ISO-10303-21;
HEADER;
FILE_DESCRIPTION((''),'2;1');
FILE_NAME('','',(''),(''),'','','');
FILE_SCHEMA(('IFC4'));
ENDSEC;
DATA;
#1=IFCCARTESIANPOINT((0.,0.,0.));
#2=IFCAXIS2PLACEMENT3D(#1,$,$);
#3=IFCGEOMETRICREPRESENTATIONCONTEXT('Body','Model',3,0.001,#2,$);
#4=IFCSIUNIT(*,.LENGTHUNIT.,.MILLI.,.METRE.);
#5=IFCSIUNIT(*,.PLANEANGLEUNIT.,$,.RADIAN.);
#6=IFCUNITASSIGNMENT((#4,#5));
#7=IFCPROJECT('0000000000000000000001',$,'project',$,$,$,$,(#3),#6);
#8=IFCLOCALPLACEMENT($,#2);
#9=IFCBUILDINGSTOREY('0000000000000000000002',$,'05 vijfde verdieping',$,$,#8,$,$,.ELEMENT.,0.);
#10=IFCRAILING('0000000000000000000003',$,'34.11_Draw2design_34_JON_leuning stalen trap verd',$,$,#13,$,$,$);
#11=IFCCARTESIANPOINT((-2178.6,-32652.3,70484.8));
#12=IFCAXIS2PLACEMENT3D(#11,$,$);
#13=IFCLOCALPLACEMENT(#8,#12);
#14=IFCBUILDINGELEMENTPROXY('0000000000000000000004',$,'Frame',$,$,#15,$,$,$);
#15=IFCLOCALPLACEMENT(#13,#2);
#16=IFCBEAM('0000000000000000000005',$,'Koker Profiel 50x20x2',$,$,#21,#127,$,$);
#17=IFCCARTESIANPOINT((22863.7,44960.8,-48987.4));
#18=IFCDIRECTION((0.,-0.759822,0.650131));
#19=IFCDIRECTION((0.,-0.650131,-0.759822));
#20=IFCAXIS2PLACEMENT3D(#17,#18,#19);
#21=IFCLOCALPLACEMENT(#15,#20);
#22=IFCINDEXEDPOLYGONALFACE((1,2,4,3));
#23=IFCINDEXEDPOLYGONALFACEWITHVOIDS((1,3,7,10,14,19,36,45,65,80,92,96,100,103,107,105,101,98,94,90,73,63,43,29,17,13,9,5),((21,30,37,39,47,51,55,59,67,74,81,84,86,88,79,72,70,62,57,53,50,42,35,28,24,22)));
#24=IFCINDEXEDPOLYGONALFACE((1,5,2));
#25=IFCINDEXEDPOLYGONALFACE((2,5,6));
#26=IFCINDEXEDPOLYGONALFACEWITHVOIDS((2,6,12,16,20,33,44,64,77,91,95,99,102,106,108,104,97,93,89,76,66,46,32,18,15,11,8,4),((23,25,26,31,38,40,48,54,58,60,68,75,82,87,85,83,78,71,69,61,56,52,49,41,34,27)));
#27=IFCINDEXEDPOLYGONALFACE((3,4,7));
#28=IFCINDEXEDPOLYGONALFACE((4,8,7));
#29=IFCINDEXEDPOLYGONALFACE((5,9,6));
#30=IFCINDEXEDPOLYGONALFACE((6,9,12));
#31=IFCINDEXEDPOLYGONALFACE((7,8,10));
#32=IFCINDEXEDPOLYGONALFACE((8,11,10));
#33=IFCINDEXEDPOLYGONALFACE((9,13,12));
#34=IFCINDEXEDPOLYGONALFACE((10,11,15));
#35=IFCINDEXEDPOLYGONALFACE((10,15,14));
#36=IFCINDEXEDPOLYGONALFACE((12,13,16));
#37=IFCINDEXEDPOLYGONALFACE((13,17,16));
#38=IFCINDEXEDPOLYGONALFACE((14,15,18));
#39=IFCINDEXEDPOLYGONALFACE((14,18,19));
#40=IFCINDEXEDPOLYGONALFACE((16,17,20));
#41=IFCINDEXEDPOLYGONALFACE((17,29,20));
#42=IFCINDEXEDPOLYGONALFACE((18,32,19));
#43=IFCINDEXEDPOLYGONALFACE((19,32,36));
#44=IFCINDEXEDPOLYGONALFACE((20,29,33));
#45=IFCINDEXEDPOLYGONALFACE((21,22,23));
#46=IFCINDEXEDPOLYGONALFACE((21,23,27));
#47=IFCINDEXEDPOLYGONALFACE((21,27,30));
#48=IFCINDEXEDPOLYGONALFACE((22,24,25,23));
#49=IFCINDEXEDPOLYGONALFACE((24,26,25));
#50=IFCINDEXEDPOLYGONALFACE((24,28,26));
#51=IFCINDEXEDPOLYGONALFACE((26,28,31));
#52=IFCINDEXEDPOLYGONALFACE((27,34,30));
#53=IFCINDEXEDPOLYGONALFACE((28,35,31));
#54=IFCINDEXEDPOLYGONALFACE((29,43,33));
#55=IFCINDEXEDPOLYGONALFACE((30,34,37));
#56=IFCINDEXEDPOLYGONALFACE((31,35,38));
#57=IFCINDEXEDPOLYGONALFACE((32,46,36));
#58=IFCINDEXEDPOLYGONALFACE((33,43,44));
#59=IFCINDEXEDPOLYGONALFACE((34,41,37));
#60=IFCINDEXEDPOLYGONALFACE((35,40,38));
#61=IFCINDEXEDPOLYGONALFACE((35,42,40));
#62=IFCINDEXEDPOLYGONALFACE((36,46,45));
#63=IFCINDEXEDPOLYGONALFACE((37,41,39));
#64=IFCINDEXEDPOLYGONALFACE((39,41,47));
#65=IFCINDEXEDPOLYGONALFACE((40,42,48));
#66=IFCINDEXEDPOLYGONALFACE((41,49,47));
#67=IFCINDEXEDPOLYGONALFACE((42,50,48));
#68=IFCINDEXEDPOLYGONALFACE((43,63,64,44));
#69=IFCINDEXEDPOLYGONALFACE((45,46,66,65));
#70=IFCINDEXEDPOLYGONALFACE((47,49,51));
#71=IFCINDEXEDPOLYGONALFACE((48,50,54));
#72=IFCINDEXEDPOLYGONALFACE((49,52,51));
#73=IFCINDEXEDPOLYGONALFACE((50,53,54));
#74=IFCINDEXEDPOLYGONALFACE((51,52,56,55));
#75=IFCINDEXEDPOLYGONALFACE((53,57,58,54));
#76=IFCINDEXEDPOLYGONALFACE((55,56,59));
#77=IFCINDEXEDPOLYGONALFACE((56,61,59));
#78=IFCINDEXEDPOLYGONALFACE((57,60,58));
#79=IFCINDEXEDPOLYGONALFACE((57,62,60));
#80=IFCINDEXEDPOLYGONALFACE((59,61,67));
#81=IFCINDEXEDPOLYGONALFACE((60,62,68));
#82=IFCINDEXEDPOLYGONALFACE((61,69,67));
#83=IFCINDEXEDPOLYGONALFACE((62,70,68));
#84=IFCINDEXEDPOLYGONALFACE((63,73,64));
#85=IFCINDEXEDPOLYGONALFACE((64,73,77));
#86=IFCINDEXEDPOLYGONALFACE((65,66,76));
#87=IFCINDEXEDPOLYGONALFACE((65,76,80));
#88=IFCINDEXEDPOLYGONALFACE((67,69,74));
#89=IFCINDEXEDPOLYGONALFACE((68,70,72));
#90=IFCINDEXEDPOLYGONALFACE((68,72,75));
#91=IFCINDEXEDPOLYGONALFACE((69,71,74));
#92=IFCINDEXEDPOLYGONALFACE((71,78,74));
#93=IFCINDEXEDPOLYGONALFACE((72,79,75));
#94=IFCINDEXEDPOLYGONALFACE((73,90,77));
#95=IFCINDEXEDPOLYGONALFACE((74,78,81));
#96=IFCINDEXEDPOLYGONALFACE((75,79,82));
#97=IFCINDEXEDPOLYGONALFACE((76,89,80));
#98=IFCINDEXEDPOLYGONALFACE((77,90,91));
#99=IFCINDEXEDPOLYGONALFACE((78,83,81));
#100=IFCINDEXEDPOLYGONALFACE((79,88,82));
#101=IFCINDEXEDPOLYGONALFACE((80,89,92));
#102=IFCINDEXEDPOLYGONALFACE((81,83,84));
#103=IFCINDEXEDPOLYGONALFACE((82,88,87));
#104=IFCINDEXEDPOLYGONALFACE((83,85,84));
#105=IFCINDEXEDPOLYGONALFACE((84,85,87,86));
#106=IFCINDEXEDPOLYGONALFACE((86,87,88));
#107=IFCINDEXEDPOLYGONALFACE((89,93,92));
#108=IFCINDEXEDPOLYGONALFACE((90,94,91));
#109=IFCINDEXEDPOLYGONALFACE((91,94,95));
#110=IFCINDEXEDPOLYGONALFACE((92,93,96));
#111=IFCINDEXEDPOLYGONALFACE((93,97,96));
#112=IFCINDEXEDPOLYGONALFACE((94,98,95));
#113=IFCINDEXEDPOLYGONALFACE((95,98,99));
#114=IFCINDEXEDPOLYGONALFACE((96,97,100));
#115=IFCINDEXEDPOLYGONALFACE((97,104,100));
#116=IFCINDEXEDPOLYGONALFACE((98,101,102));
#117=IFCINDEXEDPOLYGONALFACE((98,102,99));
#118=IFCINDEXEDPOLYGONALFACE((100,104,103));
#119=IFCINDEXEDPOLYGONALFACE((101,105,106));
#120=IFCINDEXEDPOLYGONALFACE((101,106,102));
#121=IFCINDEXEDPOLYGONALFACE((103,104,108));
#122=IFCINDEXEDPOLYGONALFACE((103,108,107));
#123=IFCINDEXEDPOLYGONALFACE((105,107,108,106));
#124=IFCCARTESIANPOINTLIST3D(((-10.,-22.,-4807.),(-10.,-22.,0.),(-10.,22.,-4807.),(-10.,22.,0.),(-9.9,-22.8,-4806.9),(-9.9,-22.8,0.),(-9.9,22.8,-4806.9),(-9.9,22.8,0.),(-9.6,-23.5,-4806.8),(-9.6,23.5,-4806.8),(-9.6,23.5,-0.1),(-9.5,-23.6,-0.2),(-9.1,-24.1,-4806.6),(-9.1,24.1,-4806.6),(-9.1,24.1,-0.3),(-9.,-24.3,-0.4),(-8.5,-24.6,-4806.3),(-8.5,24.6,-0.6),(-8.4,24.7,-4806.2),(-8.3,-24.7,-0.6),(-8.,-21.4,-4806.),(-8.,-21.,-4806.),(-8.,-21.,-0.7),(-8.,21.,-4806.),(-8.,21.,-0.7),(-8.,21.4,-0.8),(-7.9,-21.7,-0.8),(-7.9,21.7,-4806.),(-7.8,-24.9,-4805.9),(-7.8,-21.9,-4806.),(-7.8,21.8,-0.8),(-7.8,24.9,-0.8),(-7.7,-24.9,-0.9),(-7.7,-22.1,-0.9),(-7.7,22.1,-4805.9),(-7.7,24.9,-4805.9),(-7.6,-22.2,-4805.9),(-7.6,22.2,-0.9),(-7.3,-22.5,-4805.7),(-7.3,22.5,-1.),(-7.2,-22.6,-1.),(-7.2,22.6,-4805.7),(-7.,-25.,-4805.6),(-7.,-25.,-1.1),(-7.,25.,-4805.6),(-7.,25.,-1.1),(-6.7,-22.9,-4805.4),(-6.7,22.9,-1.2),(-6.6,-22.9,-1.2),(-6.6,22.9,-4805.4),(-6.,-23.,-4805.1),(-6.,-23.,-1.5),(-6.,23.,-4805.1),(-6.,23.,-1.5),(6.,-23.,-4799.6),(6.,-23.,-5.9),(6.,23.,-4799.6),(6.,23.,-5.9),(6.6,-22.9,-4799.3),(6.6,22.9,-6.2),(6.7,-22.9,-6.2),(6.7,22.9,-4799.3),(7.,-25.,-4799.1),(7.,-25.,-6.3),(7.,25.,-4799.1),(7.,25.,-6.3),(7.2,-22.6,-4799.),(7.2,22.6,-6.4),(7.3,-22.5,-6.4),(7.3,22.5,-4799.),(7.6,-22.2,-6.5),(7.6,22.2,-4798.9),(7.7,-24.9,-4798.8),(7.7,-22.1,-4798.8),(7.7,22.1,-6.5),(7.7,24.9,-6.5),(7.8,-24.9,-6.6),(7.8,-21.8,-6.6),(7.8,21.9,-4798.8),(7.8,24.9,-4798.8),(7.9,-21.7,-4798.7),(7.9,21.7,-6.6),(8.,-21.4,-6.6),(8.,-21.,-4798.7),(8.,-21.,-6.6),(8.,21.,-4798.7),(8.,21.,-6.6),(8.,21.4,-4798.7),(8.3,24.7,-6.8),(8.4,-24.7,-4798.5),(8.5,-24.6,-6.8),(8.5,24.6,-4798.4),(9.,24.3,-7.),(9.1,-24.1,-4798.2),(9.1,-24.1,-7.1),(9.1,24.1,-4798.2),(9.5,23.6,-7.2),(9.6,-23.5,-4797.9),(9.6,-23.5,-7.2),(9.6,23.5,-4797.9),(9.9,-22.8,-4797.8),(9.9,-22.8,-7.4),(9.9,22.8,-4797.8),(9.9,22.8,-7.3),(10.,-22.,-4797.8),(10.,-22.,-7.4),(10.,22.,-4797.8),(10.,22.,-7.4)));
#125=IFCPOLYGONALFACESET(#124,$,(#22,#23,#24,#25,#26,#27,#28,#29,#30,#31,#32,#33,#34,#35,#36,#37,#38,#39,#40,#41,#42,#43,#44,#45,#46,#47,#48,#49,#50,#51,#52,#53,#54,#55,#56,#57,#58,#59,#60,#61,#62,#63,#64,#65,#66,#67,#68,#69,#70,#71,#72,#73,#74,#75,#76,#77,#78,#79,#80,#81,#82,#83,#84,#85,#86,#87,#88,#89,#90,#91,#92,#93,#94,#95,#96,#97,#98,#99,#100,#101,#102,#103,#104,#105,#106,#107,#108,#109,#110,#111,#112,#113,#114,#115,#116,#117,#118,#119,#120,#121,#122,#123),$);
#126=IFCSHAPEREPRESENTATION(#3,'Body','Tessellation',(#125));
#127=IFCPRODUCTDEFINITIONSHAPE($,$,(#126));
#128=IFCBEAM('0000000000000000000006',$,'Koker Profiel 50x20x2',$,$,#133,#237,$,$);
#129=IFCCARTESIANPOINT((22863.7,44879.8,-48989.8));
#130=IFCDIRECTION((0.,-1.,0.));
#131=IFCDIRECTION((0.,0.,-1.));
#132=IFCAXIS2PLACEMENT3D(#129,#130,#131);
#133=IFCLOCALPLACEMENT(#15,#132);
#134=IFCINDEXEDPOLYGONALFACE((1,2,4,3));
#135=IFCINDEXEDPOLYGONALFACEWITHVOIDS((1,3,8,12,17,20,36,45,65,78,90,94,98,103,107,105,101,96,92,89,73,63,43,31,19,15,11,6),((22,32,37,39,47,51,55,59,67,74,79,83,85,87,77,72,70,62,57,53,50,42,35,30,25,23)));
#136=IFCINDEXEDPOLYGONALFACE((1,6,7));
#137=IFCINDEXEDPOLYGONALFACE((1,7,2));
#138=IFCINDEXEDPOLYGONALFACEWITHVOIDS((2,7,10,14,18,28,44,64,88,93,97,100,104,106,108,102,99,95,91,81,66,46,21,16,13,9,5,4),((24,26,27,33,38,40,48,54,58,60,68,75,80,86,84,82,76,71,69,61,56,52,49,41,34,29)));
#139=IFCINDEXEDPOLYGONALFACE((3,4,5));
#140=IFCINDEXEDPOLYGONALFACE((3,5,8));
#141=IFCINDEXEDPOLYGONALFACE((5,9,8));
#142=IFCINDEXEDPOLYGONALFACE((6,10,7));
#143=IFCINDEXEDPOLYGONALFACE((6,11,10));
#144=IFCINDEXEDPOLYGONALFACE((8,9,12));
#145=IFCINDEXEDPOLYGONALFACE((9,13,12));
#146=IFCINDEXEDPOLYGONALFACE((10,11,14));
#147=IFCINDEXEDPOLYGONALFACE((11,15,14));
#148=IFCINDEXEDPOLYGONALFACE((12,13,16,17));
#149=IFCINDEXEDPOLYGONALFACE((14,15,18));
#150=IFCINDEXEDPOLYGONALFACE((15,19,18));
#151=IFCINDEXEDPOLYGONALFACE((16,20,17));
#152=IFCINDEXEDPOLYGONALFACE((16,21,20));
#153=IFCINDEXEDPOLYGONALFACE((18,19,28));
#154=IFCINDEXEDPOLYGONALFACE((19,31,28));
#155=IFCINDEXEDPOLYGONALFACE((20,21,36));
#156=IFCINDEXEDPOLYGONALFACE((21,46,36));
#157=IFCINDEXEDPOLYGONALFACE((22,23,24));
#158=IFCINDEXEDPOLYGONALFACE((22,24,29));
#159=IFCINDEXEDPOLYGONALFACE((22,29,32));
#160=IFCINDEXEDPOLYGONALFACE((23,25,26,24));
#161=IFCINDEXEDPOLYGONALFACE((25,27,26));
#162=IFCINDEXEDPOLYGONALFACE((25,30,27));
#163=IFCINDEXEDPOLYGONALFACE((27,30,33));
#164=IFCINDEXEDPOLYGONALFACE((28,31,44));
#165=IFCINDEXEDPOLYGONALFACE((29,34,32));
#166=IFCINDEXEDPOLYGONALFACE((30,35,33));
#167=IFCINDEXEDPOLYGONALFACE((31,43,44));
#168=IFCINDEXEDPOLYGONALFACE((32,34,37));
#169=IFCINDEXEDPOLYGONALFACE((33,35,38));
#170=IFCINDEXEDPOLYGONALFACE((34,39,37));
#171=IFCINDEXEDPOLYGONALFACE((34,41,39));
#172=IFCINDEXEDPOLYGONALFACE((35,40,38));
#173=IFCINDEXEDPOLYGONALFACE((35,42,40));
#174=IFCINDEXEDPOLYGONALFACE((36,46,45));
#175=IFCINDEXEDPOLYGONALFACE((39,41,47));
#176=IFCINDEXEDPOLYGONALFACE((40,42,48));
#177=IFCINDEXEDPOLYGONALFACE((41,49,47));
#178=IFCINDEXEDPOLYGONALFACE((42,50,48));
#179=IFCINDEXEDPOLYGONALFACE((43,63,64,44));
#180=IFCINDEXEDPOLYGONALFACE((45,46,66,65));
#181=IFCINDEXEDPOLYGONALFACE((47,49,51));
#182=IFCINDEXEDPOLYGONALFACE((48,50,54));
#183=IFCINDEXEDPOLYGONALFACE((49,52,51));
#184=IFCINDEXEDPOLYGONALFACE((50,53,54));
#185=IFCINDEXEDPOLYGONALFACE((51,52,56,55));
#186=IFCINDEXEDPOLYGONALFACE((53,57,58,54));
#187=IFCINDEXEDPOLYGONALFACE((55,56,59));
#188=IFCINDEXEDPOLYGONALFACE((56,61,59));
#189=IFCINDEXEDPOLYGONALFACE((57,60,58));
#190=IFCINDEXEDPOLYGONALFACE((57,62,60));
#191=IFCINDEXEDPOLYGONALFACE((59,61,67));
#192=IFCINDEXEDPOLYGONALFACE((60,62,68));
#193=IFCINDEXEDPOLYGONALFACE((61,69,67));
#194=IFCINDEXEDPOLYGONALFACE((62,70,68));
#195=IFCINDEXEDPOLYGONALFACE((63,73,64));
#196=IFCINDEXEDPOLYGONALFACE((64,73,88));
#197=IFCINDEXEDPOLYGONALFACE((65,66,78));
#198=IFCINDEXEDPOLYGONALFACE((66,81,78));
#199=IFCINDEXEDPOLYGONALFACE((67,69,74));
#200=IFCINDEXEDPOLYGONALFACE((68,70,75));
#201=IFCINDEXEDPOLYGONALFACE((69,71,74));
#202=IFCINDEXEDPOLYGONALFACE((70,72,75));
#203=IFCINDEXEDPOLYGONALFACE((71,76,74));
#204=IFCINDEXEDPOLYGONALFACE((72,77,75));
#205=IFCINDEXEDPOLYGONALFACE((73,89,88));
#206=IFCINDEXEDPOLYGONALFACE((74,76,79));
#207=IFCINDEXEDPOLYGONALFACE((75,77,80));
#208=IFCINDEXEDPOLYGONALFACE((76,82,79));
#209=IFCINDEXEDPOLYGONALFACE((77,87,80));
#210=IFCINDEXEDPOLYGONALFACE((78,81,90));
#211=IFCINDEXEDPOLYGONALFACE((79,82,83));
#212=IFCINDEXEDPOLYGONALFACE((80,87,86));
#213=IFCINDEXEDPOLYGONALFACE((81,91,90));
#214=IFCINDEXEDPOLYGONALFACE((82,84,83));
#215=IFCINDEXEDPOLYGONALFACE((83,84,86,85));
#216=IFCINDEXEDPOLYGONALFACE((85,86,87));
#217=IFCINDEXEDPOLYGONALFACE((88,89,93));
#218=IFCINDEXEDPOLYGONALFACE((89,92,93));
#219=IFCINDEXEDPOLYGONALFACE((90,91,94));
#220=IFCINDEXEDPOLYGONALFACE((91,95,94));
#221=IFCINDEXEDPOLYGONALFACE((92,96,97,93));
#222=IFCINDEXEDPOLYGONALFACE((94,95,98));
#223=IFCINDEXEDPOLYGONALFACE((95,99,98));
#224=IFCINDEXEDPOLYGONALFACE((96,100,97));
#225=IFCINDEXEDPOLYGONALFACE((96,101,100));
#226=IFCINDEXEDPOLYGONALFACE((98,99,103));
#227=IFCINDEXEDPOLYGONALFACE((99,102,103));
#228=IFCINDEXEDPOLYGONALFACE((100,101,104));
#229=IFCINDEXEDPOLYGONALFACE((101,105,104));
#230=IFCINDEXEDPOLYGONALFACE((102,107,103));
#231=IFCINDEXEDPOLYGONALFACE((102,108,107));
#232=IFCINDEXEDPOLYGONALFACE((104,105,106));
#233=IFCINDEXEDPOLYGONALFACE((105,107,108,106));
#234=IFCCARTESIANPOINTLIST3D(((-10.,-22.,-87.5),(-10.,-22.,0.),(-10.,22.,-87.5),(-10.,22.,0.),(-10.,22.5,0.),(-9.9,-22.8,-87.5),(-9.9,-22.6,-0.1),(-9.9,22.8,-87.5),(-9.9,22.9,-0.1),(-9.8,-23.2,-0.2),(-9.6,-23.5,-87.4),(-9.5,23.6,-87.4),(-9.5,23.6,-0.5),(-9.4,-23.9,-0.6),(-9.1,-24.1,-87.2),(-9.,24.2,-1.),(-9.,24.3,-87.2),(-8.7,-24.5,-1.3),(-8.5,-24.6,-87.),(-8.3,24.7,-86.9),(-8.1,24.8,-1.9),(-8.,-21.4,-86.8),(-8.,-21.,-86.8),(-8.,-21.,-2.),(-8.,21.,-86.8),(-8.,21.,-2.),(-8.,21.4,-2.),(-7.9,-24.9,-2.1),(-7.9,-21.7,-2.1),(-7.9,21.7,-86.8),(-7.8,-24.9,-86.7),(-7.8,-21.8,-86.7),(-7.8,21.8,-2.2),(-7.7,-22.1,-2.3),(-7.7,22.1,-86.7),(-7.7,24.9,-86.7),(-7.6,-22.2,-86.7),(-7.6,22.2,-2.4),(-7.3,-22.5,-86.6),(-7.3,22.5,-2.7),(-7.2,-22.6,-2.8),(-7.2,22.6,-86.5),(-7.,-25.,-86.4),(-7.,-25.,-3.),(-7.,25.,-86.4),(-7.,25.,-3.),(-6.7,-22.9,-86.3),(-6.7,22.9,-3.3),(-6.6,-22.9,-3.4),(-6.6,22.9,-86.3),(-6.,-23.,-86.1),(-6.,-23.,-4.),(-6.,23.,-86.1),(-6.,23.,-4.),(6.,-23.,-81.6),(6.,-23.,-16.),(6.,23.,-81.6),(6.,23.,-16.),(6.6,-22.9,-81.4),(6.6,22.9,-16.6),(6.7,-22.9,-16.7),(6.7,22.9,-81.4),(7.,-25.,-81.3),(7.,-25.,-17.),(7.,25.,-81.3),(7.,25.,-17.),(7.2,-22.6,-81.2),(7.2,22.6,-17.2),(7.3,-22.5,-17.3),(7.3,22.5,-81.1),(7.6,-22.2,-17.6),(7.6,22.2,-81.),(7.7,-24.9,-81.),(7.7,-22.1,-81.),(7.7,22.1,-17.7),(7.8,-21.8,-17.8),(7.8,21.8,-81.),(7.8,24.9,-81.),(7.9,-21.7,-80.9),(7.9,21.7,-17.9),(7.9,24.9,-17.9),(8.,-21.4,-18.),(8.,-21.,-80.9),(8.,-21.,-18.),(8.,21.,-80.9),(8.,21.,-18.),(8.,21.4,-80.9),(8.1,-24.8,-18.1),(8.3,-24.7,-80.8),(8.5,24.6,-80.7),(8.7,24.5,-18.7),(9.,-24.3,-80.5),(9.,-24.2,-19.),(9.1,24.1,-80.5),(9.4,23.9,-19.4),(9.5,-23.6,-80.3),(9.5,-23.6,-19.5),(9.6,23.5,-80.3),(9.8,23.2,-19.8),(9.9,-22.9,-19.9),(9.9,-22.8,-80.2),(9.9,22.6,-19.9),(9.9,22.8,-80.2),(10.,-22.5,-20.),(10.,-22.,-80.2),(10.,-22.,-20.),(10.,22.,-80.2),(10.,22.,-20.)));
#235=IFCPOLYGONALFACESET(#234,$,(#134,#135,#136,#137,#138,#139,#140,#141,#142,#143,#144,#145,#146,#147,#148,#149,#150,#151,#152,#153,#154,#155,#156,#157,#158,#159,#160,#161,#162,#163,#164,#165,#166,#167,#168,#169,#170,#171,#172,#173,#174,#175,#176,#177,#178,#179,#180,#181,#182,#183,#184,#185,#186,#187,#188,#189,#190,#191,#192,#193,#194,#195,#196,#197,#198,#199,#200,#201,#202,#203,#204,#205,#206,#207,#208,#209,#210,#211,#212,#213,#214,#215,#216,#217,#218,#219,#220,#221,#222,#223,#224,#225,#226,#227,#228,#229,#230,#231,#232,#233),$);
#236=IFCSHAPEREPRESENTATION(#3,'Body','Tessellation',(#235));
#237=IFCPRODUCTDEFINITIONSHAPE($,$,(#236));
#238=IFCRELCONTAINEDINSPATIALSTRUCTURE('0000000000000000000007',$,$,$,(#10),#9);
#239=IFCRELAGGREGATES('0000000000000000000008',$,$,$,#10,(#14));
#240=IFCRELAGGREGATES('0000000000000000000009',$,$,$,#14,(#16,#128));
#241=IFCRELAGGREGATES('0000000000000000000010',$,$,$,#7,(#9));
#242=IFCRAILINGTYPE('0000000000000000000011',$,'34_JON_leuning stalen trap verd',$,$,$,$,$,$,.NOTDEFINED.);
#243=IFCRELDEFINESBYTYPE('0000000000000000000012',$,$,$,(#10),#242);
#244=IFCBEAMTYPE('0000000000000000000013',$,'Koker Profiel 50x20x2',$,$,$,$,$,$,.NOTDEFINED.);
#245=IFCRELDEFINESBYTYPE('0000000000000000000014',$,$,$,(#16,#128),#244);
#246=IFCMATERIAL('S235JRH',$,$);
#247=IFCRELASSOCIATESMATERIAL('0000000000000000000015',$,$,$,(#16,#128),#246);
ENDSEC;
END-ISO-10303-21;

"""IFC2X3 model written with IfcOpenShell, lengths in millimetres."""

from ifc_helpers import new_model, si_unit, frame, origin, origin_2d, place, context, project, spatial, hollow_rectangle, extrude, clip, halfspace, source, transform, mapped, material, type_object, element, aggregate, save


model = new_model("IFC2X3")

# Units and contexts
model_context = context("Model", 3, precision=0.001, world=origin(), identifier="Body")
ifc_project = project(units=[si_unit("LENGTHUNIT", "METRE", prefix="MILLI"), si_unit("PLANEANGLEUNIT", "RADIAN")], contexts=[model_context])

# Storey
storey_placement = place(None, origin())
storey = spatial("IfcBuildingStorey", under=ifc_project, at=storey_placement, Name="05 vijfde verdieping", CompositionType="ELEMENT", Elevation=0.0)

# Railing
railing_type = type_object("IfcRailingType", Name="34_JON_leuning stalen trap verd")
railing_placement = place(storey_placement, frame((-2178.6, -32652.3, 70484.8)))
railing = element("IfcRailing", 1, at=railing_placement, inside=storey, type_object=railing_type, Name="34.11_Draw2design_34_JON_leuning stalen trap verd")
ifc_material_1 = material(Name="S235JRH")

# Building element proxy
proxy_1_placement = place(railing_placement, origin())
proxy_1 = element("IfcBuildingElementProxy", 2, at=proxy_1_placement, Name="Frame")
aggregate(railing, [proxy_1])

# Beams
beam_type_1 = type_object("IfcBeamType", Name="Koker Profiel 50x20x2")
shared_shape_1 = source(origin(), model_context, "Body", "Clipping", [
    clip(clip(extrude(hollow_rectangle(XDim=20.0, YDim=50.0, WallThickness=2.0, InnerFilletRadius=2.0, OuterFilletRadius=3.0, at=origin_2d()), origin(), (0.0, 0.0, -1.0), 4807.0), halfspace(frame((-8.8, -25.0, -0.5), z_axis=(0.346539, 0.0, 0.938036), x_axis=(0.0, -1.0, 0.0)), False)), halfspace(frame((-8.2, 25.0, -4806.1), z_axis=(0.418252, 0.0, -0.908331), x_axis=(-0.908331, 0.0, -0.418252)), False)),
])
beam_1_placement = place(proxy_1_placement, frame((22863.7, 44960.8, -48987.4), z_axis=(0.0, -0.759822, 0.650131), x_axis=(0.0, -0.650131, -0.759822)))
beam_1 = element("IfcBeam", 3, at=beam_1_placement, type_object=beam_type_1, material=ifc_material_1, Name="Koker Profiel 50x20x2", context=model_context, shape_type="MappedRepresentation", body=[
    mapped(shared_shape_1, transform((0.0, 0.0, 0.0), scale=1.0)),
])
shared_shape_2 = source(origin(), model_context, "Body", "Clipping", [
    clip(clip(extrude(hollow_rectangle(XDim=20.0, YDim=50.0, WallThickness=2.0, InnerFilletRadius=2.0, OuterFilletRadius=3.0, at=origin_2d()), origin(), (0.0, 0.0, -1.0), 87.5), halfspace(frame((-4.1, -25.0, -5.9), z_axis=(0.707107, 0.0, 0.707107), x_axis=(0.707107, 0.0, -0.707107)), False)), halfspace(frame((-8.8, 25.0, -87.1), z_axis=(0.346539, 0.0, -0.938036), x_axis=(0.0, 1.0, 0.0)), False)),
])
beam_2_placement = place(proxy_1_placement, frame((22863.7, 44879.8, -48989.8), z_axis=(0.0, -1.0, 0.0), x_axis=(0.0, 0.0, -1.0)))
beam_2 = element("IfcBeam", 4, at=beam_2_placement, type_object=beam_type_1, material=ifc_material_1, Name="Koker Profiel 50x20x2", context=model_context, shape_type="MappedRepresentation", body=[
    mapped(shared_shape_2, transform((0.0, 0.0, 0.0), scale=1.0)),
])
aggregate(proxy_1, [beam_1, beam_2])

save(model, "model.ifc")
